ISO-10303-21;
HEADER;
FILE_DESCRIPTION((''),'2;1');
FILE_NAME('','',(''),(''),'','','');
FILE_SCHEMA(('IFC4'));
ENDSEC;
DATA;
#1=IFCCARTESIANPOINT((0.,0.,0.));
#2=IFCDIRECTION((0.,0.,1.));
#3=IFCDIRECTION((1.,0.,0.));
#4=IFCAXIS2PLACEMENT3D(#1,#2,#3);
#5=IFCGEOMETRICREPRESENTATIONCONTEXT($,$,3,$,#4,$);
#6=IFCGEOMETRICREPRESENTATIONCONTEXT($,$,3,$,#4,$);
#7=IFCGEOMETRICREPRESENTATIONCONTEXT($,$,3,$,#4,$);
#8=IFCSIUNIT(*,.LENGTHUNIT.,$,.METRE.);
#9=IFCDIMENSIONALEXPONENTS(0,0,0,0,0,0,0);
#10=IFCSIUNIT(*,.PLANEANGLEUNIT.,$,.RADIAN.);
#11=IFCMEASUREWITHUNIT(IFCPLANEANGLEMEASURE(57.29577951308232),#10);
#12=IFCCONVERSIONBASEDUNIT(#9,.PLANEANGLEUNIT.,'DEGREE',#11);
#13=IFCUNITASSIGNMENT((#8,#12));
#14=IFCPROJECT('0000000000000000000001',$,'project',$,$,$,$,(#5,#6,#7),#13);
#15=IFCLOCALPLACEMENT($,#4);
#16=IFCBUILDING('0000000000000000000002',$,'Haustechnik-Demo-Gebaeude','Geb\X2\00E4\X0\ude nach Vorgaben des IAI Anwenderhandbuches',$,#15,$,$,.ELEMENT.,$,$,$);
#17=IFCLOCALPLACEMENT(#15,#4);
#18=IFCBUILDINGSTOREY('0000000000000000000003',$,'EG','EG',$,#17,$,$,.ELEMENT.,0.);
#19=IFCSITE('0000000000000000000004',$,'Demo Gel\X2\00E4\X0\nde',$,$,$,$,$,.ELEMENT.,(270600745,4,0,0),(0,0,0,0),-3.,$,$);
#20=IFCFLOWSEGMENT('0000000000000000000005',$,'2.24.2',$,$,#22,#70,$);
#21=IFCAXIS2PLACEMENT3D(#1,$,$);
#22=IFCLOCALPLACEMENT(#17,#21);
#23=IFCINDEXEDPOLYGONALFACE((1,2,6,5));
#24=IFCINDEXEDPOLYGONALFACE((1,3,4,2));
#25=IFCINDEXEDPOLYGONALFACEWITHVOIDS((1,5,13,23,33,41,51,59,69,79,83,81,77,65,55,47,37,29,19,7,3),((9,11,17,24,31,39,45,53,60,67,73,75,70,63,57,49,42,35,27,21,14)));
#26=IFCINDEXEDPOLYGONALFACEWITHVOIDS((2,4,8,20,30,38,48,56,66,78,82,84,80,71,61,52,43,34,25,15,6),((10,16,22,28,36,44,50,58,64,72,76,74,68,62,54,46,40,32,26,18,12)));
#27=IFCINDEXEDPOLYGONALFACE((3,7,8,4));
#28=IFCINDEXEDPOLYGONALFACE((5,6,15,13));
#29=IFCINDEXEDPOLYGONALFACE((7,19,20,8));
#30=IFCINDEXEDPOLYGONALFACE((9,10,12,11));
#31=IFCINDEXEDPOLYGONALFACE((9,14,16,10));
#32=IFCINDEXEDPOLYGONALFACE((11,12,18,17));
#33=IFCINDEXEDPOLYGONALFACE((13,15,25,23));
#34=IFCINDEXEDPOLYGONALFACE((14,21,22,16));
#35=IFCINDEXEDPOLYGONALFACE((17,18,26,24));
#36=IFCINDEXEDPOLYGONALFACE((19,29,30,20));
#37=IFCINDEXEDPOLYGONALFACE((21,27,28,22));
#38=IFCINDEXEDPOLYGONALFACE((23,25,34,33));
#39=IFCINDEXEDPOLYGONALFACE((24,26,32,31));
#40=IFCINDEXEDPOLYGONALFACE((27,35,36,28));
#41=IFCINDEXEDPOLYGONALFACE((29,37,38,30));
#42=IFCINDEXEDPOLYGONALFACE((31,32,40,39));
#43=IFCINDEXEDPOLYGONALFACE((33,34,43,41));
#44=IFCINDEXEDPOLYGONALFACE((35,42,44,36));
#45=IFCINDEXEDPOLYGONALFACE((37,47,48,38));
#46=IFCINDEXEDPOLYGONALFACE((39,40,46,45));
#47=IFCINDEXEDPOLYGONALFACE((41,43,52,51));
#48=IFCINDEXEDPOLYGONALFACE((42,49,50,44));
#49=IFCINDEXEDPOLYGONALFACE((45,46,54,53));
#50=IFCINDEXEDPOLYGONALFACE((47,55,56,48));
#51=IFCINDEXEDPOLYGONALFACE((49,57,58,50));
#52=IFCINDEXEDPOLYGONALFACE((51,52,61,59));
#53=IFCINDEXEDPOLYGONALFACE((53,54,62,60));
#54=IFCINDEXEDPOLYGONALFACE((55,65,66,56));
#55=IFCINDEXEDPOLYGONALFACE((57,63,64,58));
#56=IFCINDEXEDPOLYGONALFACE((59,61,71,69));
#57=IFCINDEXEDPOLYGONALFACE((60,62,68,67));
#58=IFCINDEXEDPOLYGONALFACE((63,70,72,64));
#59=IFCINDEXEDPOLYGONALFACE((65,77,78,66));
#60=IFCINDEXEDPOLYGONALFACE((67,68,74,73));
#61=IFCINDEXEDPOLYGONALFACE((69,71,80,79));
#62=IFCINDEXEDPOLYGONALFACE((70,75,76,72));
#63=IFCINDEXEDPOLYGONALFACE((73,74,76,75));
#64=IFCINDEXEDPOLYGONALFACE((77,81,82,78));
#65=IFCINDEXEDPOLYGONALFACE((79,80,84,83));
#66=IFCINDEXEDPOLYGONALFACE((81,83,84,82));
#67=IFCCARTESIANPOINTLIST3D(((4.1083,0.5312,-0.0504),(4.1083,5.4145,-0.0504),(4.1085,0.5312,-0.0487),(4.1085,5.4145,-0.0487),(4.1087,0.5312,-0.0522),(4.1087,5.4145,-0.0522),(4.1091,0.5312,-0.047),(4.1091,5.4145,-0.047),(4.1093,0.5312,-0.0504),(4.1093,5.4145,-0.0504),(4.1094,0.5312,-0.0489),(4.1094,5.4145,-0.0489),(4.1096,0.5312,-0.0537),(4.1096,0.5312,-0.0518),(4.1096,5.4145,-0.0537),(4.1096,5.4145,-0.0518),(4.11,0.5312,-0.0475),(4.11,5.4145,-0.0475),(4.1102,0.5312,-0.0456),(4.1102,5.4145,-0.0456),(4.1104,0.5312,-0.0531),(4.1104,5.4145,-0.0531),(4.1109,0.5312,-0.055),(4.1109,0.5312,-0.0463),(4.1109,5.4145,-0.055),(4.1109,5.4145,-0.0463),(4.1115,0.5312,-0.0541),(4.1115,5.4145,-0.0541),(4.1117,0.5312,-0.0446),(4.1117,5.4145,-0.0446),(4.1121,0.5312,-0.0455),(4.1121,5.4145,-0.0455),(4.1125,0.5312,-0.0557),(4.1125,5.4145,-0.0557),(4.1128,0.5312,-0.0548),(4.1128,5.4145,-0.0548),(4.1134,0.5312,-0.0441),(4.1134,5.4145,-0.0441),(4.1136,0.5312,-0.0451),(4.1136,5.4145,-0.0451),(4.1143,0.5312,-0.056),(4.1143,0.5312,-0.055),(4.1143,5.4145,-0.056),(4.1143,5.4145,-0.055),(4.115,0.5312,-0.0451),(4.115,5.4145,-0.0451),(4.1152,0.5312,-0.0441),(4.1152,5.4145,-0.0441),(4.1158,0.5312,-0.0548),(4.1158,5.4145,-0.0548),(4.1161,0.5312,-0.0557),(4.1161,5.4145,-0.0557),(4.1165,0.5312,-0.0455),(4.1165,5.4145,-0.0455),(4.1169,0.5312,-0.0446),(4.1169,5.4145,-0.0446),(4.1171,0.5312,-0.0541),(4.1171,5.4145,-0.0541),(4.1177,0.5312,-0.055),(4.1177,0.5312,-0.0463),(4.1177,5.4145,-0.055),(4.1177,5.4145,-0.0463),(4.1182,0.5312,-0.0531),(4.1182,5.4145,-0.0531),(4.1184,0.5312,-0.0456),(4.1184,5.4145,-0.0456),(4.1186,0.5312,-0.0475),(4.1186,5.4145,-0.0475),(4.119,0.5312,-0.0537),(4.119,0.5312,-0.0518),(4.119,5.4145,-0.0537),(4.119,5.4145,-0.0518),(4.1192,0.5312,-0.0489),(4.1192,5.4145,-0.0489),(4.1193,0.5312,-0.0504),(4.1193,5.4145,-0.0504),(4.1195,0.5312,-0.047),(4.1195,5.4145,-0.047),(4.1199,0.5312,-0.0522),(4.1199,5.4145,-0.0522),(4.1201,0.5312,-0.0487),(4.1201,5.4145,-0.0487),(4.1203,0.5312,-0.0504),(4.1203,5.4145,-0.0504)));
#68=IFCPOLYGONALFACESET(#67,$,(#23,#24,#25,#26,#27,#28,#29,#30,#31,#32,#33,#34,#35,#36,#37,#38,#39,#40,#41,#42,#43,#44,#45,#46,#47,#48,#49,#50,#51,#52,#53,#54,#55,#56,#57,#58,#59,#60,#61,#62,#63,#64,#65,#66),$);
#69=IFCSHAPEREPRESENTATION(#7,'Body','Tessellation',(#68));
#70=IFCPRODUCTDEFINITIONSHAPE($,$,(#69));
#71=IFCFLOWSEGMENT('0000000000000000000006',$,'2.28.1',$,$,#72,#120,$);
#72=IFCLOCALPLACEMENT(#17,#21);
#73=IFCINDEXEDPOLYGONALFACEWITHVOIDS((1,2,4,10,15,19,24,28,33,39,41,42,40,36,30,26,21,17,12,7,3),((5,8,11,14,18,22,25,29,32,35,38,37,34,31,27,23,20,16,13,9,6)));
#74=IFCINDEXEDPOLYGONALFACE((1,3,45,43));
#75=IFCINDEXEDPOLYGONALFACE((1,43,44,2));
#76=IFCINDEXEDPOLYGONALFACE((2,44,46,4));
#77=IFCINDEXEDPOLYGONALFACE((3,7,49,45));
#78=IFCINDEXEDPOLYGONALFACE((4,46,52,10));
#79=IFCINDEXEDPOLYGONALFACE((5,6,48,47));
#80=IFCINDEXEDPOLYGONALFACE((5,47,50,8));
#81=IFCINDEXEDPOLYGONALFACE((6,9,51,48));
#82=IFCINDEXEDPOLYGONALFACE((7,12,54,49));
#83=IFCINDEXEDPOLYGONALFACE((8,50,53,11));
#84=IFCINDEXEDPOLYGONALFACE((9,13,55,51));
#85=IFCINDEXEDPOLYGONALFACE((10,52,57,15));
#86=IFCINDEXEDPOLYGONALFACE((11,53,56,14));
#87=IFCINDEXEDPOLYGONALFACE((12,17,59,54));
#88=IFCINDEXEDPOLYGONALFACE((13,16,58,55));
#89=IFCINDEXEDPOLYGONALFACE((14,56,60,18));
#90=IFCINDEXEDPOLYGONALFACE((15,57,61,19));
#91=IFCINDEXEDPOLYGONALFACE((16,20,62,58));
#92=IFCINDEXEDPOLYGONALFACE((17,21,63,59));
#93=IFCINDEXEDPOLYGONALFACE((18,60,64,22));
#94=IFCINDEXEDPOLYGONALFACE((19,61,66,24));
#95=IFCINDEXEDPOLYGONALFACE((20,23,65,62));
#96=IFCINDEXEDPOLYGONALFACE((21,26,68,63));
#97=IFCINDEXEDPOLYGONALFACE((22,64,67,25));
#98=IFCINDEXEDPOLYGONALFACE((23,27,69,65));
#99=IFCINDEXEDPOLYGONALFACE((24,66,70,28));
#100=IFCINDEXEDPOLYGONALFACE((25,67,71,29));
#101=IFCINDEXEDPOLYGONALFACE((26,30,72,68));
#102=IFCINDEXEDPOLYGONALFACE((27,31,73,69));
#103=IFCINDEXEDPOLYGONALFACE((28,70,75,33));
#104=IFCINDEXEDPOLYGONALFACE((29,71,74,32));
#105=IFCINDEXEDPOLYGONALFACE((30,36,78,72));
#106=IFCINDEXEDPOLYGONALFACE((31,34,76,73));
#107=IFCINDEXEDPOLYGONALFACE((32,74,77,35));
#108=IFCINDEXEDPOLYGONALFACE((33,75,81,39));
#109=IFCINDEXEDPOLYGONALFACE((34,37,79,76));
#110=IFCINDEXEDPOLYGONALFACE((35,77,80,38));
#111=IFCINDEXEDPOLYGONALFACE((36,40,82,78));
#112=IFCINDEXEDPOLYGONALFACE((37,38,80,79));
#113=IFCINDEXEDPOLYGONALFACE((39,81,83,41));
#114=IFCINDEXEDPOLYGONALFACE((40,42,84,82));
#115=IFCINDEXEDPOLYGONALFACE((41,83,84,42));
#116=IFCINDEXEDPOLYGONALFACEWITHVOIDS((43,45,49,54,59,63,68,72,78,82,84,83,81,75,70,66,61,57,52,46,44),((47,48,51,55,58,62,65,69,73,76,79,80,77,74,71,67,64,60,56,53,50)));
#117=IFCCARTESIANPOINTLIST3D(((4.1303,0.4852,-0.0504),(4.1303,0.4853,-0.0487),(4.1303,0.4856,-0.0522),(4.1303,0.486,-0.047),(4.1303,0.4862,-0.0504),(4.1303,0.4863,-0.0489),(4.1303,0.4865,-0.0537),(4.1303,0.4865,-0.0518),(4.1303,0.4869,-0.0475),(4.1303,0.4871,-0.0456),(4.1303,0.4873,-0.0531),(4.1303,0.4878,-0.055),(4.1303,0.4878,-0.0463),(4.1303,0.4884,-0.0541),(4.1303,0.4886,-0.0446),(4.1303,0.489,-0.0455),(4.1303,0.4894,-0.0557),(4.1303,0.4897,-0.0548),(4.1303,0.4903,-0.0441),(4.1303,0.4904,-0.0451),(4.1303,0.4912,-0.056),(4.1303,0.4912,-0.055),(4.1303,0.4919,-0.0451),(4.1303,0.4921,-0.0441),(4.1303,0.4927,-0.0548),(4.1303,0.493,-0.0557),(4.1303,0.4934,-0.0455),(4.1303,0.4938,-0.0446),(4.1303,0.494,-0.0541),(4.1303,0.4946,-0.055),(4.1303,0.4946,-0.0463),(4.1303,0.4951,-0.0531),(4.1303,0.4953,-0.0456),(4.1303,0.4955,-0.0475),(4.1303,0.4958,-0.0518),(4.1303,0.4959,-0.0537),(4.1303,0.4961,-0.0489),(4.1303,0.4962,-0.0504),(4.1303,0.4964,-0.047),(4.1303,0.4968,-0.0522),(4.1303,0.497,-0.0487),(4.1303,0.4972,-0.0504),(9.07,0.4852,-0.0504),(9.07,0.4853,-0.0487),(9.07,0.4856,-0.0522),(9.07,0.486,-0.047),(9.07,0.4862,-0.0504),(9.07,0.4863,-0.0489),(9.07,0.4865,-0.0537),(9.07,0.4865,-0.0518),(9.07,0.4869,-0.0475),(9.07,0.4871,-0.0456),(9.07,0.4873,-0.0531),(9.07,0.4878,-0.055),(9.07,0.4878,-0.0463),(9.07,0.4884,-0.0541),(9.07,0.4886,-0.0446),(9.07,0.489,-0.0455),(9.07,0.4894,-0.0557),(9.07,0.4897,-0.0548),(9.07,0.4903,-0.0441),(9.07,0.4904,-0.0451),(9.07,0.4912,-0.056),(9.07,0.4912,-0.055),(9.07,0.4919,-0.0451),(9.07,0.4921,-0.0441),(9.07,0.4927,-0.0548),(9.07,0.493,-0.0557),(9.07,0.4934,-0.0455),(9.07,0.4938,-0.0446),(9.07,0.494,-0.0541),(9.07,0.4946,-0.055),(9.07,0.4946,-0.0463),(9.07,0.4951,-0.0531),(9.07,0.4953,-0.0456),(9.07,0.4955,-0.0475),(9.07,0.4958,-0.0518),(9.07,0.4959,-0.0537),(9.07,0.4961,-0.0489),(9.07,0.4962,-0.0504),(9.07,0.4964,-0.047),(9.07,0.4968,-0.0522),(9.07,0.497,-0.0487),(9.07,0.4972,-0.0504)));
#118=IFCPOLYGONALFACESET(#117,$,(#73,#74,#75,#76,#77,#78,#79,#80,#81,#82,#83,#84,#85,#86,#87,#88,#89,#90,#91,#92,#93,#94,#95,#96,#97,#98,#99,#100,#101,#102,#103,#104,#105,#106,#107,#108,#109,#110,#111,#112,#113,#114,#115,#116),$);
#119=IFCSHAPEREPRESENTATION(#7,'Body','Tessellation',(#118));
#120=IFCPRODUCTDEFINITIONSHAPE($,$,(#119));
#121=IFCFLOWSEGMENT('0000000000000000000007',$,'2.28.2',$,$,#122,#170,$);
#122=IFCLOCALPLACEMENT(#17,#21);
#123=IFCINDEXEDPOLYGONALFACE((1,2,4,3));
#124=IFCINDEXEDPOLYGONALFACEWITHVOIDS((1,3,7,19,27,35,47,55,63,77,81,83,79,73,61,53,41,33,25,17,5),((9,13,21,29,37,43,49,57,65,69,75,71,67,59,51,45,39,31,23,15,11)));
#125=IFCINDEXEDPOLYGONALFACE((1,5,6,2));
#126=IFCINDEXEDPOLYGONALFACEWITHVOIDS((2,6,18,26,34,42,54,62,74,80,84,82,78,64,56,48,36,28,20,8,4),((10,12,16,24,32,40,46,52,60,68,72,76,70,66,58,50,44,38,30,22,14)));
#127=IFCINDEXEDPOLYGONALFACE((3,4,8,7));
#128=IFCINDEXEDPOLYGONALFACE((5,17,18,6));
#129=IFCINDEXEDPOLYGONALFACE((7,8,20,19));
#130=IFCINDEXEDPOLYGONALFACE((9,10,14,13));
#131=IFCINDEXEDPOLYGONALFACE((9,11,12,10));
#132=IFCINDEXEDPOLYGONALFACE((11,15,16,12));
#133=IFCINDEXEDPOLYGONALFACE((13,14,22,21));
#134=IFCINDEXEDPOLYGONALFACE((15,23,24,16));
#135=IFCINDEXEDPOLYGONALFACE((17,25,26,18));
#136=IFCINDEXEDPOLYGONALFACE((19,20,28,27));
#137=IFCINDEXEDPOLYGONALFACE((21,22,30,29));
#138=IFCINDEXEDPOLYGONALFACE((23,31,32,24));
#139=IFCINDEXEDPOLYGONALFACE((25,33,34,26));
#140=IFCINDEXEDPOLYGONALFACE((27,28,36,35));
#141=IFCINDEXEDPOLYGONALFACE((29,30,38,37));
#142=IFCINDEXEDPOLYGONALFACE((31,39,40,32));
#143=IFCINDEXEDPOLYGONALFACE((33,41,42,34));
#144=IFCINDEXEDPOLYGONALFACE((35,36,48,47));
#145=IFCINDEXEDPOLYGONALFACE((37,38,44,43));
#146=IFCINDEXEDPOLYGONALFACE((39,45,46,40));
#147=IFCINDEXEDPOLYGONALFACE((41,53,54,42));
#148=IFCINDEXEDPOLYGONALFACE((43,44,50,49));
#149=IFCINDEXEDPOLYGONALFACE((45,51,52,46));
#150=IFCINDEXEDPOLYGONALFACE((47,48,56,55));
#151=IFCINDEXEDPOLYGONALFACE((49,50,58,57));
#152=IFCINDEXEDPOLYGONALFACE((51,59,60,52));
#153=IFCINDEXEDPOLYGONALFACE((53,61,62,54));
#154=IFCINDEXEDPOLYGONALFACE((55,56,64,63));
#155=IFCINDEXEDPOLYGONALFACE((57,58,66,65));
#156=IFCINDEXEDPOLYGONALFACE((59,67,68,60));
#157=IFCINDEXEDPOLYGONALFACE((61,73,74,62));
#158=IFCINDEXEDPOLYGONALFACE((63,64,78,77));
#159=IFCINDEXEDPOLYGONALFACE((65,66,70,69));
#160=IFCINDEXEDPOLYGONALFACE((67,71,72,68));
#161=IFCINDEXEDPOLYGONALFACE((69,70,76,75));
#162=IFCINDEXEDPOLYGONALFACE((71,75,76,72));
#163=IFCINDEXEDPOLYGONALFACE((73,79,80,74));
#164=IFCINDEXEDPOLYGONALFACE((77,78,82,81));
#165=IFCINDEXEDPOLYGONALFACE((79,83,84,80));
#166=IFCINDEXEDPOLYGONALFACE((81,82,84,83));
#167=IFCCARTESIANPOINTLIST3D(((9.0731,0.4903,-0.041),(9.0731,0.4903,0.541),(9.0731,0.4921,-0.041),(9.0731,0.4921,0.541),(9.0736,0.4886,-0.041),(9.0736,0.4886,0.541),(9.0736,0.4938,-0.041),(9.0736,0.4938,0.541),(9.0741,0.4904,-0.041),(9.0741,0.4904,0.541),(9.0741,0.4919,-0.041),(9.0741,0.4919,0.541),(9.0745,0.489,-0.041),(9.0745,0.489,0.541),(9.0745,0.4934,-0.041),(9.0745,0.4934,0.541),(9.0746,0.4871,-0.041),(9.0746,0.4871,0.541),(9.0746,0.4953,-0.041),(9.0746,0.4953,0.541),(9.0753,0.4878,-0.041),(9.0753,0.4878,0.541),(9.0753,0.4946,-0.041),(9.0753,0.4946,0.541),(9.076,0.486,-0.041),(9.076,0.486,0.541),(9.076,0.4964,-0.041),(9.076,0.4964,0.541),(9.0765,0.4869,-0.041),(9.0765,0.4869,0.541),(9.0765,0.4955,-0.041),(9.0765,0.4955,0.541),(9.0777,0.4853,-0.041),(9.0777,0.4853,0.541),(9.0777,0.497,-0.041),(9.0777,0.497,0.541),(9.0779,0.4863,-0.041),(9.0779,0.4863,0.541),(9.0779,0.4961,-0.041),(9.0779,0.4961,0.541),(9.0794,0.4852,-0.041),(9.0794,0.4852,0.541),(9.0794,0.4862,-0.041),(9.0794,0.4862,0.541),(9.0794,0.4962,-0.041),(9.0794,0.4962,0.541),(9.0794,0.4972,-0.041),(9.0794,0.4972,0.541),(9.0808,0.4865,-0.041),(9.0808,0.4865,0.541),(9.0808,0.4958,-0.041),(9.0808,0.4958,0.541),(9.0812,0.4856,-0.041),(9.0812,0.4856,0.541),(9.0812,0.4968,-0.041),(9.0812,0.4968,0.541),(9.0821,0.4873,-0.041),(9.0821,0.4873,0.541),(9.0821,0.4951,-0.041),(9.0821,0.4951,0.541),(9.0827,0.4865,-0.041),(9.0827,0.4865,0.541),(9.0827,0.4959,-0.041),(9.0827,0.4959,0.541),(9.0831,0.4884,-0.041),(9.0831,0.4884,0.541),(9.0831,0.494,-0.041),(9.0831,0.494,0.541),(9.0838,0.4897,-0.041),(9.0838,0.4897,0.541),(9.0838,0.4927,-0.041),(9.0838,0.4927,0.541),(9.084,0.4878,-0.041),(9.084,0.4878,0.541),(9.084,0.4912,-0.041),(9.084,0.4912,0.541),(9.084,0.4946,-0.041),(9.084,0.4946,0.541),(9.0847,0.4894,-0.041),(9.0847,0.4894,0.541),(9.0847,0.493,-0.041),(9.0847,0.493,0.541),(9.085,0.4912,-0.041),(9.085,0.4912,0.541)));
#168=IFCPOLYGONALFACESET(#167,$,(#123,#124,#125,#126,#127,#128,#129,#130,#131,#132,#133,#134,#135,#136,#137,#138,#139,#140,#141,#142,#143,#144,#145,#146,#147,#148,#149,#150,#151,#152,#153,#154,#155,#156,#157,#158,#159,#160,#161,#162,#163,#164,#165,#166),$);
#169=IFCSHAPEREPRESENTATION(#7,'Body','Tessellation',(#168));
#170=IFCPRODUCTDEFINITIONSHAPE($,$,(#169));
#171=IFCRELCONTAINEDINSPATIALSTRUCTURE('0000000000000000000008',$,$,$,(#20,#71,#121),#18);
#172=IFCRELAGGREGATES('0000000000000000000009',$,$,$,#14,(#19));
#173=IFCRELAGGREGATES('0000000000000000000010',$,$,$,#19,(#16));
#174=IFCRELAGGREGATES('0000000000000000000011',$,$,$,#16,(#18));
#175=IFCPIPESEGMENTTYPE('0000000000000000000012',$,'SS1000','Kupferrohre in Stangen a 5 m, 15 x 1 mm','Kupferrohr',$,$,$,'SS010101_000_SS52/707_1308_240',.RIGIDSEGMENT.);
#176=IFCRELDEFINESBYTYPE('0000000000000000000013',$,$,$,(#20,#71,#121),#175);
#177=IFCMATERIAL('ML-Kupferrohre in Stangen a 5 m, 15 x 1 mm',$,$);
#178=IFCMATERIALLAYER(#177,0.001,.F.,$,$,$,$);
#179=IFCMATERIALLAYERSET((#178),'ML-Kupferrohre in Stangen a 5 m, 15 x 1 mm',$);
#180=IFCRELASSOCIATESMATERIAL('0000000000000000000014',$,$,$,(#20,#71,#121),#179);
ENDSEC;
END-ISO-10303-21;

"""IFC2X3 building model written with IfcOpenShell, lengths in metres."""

from ifc_helpers import new_model, entity, si_unit, converted_unit, frame, origin_with_axes, origin_2d_with_axis, place, context, project, spatial, hollow_circle, extrude, material, layer, layer_set, layer_usage, type_object, element, save


model = new_model("IFC2X3")

# Units and contexts
context_of_model_1 = context(None, 3, world=origin_with_axes())
context_of_model_2 = context(None, 3, world=origin_with_axes())
context_of_model_3 = context(None, 3, world=origin_with_axes())
ifc_project = project(units=[si_unit("LENGTHUNIT", "METRE"), converted_unit("PLANEANGLEUNIT", "DEGREE", entity("IfcPlaneAngleMeasure", 57.29577951308232), si_unit("PLANEANGLEUNIT", "RADIAN"), dimensions=[0, 0, 0, 0, 0, 0, 0])], contexts=[context_of_model_1, context_of_model_2, context_of_model_3])

# Site, building, storey
site = spatial("IfcSite", under=ifc_project, Name="Demo Gelände", CompositionType="ELEMENT", RefLatitude=(270600745, 4, 0, 0), RefLongitude=(0, 0, 0, 0), RefElevation=-3.0)
building_placement = place(None, origin_with_axes())
building = spatial("IfcBuilding", under=site, at=building_placement, Name="Haustechnik-Demo-Gebaeude", Description="Gebäude nach Vorgaben des IAI Anwenderhandbuches", CompositionType="ELEMENT")
storey_placement = place(building_placement, origin_with_axes())
storey = spatial("IfcBuildingStorey", under=building, at=storey_placement, Name="EG", Description="EG", CompositionType="ELEMENT", Elevation=0.0)

# Flow segments
ifc_material = material(Name="ML-Kupferrohre in Stangen a 5 m, 15 x 1 mm")
ifc_layer = layer(ifc_material, 0.001, ventilated=False)
ifc_layer_set = layer_set([ifc_layer], Name="ML-Kupferrohre in Stangen a 5 m, 15 x 1 mm")
ifc_layer_usage = layer_usage(ifc_layer_set, "AXIS2", "POSITIVE", 0.0)
pipe_segment_type_1 = type_object("IfcPipeSegmentType", Name="SS1000", Description="Kupferrohre in Stangen a 5 m, 15 x 1 mm", ApplicableOccurrence="Kupferrohr", ElementType="SS010101_000_SS52/707_1308_240", PredefinedType="RIGIDSEGMENT")
flow_segment_1_placement = place(storey_placement, frame((4.1143, 5.4145, -0.05), z_axis=(0.0, -1.0, 0.0), x_axis=(0.0, 0.0, -1.0)))
element("IfcFlowSegment", 1, at=flow_segment_1_placement, inside=storey, type_object=pipe_segment_type_1, material=ifc_layer_usage, Name="2.24.2", context=context_of_model_3, shape_type="SweptSolid", body=[
    extrude(hollow_circle(Radius=0.006, WallThickness=0.001, at=origin_2d_with_axis()), origin_with_axes(), (0.0, 0.0, 1.0), 4.8833),
])
flow_segment_2_placement = place(storey_placement, frame((4.1303, 0.4912, -0.05), z_axis=(1.0, 0.0, 0.0), x_axis=(0.0, 0.0, -1.0)))
element("IfcFlowSegment", 2, at=flow_segment_2_placement, inside=storey, type_object=pipe_segment_type_1, material=ifc_layer_usage, Name="2.28.1", context=context_of_model_3, shape_type="SweptSolid", body=[
    extrude(hollow_circle(Radius=0.006, WallThickness=0.001, at=origin_2d_with_axis()), origin_with_axes(), (0.0, 0.0, 1.0), 4.9397),
])
flow_segment_3_placement = place(storey_placement, frame((9.079, 0.4912, -0.041), z_axis=(0.0, 0.0, 1.0), x_axis=(1.0, 0.0, 0.0)))
element("IfcFlowSegment", 3, at=flow_segment_3_placement, inside=storey, type_object=pipe_segment_type_1, material=ifc_layer_usage, Name="2.28.2", context=context_of_model_3, shape_type="SweptSolid", body=[
    extrude(hollow_circle(Radius=0.006, WallThickness=0.001, at=origin_2d_with_axis()), origin_with_axes(), (0.0, 0.0, 1.0), 0.582),
])

save(model, "model.ifc")
